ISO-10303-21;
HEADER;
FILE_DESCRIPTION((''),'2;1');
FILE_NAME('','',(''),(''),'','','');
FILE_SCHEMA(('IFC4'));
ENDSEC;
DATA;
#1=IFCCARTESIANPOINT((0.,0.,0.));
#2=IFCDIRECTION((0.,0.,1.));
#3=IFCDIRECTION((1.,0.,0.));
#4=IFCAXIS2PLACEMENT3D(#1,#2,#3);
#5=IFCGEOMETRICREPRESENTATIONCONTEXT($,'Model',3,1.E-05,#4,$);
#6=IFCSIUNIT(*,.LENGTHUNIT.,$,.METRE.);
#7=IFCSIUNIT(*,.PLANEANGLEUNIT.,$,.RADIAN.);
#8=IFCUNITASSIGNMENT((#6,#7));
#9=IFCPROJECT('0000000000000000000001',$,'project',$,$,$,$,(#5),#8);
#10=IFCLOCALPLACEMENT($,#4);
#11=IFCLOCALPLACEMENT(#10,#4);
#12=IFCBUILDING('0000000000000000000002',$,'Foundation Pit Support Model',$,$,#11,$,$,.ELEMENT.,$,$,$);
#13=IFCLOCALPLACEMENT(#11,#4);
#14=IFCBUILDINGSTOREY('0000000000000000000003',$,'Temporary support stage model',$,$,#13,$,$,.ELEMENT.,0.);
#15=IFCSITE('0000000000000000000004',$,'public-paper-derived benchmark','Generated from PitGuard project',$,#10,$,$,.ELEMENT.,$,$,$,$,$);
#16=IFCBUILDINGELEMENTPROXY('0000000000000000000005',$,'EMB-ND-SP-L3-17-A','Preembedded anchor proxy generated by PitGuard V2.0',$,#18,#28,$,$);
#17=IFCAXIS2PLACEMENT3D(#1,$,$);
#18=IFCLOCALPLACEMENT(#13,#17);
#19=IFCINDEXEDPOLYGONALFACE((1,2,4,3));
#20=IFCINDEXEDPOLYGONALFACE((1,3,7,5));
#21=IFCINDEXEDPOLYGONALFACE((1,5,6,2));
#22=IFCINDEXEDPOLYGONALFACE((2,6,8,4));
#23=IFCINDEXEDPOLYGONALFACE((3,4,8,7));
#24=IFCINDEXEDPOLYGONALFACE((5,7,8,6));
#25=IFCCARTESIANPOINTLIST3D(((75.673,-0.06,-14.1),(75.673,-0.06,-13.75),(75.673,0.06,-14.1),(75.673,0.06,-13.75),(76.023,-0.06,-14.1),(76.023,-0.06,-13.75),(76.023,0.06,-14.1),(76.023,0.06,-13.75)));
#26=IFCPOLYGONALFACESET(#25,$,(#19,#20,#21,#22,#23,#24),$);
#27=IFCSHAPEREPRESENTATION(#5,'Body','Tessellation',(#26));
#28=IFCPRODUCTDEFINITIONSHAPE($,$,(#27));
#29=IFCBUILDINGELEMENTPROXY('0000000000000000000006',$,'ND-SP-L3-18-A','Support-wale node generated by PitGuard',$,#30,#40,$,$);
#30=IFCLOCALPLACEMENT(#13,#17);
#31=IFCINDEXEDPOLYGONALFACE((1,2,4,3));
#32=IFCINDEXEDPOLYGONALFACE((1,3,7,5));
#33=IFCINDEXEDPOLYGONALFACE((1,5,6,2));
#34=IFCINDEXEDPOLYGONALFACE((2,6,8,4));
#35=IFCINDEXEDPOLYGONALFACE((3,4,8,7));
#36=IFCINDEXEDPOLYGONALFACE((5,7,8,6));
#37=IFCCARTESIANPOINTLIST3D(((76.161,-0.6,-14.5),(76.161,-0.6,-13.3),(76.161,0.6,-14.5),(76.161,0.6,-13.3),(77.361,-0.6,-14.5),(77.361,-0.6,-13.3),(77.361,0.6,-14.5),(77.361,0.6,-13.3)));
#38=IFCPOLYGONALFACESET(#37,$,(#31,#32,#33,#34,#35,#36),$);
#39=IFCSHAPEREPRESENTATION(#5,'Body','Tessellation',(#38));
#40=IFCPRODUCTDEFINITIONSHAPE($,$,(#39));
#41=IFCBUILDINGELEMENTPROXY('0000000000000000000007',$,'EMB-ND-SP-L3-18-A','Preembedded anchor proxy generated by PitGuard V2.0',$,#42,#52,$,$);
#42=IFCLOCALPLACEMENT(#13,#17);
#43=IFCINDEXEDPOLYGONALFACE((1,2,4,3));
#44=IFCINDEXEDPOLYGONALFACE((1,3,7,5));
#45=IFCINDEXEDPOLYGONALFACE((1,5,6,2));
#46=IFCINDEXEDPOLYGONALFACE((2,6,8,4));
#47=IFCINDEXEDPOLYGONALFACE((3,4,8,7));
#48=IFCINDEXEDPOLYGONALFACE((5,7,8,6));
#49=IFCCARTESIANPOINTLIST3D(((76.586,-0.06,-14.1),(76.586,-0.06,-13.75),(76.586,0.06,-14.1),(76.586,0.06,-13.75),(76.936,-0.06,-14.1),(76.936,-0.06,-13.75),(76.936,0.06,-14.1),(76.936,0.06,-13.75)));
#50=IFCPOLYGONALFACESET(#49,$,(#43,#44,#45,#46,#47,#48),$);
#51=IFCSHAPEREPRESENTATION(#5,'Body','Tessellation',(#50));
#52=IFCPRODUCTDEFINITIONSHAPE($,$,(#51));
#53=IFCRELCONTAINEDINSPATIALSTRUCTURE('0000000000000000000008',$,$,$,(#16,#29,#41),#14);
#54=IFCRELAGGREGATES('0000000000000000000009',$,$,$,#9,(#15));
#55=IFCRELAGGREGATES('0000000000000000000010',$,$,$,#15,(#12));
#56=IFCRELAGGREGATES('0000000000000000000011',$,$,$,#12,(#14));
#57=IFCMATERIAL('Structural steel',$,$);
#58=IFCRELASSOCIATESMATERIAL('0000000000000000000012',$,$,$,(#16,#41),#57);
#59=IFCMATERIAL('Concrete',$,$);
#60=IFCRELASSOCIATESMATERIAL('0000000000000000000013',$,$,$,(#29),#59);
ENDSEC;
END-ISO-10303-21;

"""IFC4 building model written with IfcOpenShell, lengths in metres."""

from ifc_helpers import new_model, si_unit, frame, origin_with_axes, origin_2d, place, context, project, spatial, rectangle, extrude, material, element, save


model = new_model("IFC4")

# Units and contexts
model_context = context("Model", 3, precision=1e-05, world=origin_with_axes())
ifc_project = project(units=[si_unit("LENGTHUNIT", "METRE"), si_unit("PLANEANGLEUNIT", "RADIAN")], contexts=[model_context])

# Site, building, storey
site_placement = place(None, origin_with_axes())
site = spatial("IfcSite", under=ifc_project, at=site_placement, Name="public-paper-derived benchmark", Description="Generated from PitGuard project", CompositionType="ELEMENT")
building_placement = place(site_placement, origin_with_axes())
building = spatial("IfcBuilding", under=site, at=building_placement, Name="Foundation Pit Support Model", CompositionType="ELEMENT")
storey_placement = place(building_placement, origin_with_axes())
storey = spatial("IfcBuildingStorey", under=building, at=storey_placement, Name="Temporary support stage model", CompositionType="ELEMENT", Elevation=0.0)

# Shared definitions
ifc_material_1 = material(Name="Structural steel")

# Building element proxies
ifc_material_2 = material(Name="Concrete")
proxy_1_placement = place(storey_placement, frame((75.848, 0.0, -14.1), z_axis=(0.0, 0.0, 1.0), x_axis=(1.0, 0.0, 0.0)))
element("IfcBuildingElementProxy", 1, at=proxy_1_placement, inside=storey, material=ifc_material_1, Name="EMB-ND-SP-L3-17-A", Description="Preembedded anchor proxy generated by PitGuard V2.0", context=model_context, shape_type="SweptSolid", body=[
    extrude(rectangle(XDim=0.35, YDim=0.12, at=origin_2d()), origin_with_axes(), (0.0, 0.0, 1.0), 0.35),
])
proxy_2_placement = place(storey_placement, frame((76.761, 0.0, -14.5), z_axis=(0.0, 0.0, 1.0), x_axis=(1.0, 0.0, 0.0)))
element("IfcBuildingElementProxy", 2, at=proxy_2_placement, inside=storey, material=ifc_material_2, Name="ND-SP-L3-18-A", Description="Support-wale node generated by PitGuard", context=model_context, shape_type="SweptSolid", body=[
    extrude(rectangle(XDim=1.2, YDim=1.2, at=origin_2d()), origin_with_axes(), (0.0, 0.0, 1.0), 1.2),
])
proxy_3_placement = place(storey_placement, frame((76.761, 0.0, -14.1), z_axis=(0.0, 0.0, 1.0), x_axis=(1.0, 0.0, 0.0)))
element("IfcBuildingElementProxy", 3, at=proxy_3_placement, inside=storey, material=ifc_material_1, Name="EMB-ND-SP-L3-18-A", Description="Preembedded anchor proxy generated by PitGuard V2.0", context=model_context, shape_type="SweptSolid", body=[
    extrude(rectangle(XDim=0.35, YDim=0.12, at=origin_2d()), origin_with_axes(), (0.0, 0.0, 1.0), 0.35),
])

save(model, "model.ifc")
